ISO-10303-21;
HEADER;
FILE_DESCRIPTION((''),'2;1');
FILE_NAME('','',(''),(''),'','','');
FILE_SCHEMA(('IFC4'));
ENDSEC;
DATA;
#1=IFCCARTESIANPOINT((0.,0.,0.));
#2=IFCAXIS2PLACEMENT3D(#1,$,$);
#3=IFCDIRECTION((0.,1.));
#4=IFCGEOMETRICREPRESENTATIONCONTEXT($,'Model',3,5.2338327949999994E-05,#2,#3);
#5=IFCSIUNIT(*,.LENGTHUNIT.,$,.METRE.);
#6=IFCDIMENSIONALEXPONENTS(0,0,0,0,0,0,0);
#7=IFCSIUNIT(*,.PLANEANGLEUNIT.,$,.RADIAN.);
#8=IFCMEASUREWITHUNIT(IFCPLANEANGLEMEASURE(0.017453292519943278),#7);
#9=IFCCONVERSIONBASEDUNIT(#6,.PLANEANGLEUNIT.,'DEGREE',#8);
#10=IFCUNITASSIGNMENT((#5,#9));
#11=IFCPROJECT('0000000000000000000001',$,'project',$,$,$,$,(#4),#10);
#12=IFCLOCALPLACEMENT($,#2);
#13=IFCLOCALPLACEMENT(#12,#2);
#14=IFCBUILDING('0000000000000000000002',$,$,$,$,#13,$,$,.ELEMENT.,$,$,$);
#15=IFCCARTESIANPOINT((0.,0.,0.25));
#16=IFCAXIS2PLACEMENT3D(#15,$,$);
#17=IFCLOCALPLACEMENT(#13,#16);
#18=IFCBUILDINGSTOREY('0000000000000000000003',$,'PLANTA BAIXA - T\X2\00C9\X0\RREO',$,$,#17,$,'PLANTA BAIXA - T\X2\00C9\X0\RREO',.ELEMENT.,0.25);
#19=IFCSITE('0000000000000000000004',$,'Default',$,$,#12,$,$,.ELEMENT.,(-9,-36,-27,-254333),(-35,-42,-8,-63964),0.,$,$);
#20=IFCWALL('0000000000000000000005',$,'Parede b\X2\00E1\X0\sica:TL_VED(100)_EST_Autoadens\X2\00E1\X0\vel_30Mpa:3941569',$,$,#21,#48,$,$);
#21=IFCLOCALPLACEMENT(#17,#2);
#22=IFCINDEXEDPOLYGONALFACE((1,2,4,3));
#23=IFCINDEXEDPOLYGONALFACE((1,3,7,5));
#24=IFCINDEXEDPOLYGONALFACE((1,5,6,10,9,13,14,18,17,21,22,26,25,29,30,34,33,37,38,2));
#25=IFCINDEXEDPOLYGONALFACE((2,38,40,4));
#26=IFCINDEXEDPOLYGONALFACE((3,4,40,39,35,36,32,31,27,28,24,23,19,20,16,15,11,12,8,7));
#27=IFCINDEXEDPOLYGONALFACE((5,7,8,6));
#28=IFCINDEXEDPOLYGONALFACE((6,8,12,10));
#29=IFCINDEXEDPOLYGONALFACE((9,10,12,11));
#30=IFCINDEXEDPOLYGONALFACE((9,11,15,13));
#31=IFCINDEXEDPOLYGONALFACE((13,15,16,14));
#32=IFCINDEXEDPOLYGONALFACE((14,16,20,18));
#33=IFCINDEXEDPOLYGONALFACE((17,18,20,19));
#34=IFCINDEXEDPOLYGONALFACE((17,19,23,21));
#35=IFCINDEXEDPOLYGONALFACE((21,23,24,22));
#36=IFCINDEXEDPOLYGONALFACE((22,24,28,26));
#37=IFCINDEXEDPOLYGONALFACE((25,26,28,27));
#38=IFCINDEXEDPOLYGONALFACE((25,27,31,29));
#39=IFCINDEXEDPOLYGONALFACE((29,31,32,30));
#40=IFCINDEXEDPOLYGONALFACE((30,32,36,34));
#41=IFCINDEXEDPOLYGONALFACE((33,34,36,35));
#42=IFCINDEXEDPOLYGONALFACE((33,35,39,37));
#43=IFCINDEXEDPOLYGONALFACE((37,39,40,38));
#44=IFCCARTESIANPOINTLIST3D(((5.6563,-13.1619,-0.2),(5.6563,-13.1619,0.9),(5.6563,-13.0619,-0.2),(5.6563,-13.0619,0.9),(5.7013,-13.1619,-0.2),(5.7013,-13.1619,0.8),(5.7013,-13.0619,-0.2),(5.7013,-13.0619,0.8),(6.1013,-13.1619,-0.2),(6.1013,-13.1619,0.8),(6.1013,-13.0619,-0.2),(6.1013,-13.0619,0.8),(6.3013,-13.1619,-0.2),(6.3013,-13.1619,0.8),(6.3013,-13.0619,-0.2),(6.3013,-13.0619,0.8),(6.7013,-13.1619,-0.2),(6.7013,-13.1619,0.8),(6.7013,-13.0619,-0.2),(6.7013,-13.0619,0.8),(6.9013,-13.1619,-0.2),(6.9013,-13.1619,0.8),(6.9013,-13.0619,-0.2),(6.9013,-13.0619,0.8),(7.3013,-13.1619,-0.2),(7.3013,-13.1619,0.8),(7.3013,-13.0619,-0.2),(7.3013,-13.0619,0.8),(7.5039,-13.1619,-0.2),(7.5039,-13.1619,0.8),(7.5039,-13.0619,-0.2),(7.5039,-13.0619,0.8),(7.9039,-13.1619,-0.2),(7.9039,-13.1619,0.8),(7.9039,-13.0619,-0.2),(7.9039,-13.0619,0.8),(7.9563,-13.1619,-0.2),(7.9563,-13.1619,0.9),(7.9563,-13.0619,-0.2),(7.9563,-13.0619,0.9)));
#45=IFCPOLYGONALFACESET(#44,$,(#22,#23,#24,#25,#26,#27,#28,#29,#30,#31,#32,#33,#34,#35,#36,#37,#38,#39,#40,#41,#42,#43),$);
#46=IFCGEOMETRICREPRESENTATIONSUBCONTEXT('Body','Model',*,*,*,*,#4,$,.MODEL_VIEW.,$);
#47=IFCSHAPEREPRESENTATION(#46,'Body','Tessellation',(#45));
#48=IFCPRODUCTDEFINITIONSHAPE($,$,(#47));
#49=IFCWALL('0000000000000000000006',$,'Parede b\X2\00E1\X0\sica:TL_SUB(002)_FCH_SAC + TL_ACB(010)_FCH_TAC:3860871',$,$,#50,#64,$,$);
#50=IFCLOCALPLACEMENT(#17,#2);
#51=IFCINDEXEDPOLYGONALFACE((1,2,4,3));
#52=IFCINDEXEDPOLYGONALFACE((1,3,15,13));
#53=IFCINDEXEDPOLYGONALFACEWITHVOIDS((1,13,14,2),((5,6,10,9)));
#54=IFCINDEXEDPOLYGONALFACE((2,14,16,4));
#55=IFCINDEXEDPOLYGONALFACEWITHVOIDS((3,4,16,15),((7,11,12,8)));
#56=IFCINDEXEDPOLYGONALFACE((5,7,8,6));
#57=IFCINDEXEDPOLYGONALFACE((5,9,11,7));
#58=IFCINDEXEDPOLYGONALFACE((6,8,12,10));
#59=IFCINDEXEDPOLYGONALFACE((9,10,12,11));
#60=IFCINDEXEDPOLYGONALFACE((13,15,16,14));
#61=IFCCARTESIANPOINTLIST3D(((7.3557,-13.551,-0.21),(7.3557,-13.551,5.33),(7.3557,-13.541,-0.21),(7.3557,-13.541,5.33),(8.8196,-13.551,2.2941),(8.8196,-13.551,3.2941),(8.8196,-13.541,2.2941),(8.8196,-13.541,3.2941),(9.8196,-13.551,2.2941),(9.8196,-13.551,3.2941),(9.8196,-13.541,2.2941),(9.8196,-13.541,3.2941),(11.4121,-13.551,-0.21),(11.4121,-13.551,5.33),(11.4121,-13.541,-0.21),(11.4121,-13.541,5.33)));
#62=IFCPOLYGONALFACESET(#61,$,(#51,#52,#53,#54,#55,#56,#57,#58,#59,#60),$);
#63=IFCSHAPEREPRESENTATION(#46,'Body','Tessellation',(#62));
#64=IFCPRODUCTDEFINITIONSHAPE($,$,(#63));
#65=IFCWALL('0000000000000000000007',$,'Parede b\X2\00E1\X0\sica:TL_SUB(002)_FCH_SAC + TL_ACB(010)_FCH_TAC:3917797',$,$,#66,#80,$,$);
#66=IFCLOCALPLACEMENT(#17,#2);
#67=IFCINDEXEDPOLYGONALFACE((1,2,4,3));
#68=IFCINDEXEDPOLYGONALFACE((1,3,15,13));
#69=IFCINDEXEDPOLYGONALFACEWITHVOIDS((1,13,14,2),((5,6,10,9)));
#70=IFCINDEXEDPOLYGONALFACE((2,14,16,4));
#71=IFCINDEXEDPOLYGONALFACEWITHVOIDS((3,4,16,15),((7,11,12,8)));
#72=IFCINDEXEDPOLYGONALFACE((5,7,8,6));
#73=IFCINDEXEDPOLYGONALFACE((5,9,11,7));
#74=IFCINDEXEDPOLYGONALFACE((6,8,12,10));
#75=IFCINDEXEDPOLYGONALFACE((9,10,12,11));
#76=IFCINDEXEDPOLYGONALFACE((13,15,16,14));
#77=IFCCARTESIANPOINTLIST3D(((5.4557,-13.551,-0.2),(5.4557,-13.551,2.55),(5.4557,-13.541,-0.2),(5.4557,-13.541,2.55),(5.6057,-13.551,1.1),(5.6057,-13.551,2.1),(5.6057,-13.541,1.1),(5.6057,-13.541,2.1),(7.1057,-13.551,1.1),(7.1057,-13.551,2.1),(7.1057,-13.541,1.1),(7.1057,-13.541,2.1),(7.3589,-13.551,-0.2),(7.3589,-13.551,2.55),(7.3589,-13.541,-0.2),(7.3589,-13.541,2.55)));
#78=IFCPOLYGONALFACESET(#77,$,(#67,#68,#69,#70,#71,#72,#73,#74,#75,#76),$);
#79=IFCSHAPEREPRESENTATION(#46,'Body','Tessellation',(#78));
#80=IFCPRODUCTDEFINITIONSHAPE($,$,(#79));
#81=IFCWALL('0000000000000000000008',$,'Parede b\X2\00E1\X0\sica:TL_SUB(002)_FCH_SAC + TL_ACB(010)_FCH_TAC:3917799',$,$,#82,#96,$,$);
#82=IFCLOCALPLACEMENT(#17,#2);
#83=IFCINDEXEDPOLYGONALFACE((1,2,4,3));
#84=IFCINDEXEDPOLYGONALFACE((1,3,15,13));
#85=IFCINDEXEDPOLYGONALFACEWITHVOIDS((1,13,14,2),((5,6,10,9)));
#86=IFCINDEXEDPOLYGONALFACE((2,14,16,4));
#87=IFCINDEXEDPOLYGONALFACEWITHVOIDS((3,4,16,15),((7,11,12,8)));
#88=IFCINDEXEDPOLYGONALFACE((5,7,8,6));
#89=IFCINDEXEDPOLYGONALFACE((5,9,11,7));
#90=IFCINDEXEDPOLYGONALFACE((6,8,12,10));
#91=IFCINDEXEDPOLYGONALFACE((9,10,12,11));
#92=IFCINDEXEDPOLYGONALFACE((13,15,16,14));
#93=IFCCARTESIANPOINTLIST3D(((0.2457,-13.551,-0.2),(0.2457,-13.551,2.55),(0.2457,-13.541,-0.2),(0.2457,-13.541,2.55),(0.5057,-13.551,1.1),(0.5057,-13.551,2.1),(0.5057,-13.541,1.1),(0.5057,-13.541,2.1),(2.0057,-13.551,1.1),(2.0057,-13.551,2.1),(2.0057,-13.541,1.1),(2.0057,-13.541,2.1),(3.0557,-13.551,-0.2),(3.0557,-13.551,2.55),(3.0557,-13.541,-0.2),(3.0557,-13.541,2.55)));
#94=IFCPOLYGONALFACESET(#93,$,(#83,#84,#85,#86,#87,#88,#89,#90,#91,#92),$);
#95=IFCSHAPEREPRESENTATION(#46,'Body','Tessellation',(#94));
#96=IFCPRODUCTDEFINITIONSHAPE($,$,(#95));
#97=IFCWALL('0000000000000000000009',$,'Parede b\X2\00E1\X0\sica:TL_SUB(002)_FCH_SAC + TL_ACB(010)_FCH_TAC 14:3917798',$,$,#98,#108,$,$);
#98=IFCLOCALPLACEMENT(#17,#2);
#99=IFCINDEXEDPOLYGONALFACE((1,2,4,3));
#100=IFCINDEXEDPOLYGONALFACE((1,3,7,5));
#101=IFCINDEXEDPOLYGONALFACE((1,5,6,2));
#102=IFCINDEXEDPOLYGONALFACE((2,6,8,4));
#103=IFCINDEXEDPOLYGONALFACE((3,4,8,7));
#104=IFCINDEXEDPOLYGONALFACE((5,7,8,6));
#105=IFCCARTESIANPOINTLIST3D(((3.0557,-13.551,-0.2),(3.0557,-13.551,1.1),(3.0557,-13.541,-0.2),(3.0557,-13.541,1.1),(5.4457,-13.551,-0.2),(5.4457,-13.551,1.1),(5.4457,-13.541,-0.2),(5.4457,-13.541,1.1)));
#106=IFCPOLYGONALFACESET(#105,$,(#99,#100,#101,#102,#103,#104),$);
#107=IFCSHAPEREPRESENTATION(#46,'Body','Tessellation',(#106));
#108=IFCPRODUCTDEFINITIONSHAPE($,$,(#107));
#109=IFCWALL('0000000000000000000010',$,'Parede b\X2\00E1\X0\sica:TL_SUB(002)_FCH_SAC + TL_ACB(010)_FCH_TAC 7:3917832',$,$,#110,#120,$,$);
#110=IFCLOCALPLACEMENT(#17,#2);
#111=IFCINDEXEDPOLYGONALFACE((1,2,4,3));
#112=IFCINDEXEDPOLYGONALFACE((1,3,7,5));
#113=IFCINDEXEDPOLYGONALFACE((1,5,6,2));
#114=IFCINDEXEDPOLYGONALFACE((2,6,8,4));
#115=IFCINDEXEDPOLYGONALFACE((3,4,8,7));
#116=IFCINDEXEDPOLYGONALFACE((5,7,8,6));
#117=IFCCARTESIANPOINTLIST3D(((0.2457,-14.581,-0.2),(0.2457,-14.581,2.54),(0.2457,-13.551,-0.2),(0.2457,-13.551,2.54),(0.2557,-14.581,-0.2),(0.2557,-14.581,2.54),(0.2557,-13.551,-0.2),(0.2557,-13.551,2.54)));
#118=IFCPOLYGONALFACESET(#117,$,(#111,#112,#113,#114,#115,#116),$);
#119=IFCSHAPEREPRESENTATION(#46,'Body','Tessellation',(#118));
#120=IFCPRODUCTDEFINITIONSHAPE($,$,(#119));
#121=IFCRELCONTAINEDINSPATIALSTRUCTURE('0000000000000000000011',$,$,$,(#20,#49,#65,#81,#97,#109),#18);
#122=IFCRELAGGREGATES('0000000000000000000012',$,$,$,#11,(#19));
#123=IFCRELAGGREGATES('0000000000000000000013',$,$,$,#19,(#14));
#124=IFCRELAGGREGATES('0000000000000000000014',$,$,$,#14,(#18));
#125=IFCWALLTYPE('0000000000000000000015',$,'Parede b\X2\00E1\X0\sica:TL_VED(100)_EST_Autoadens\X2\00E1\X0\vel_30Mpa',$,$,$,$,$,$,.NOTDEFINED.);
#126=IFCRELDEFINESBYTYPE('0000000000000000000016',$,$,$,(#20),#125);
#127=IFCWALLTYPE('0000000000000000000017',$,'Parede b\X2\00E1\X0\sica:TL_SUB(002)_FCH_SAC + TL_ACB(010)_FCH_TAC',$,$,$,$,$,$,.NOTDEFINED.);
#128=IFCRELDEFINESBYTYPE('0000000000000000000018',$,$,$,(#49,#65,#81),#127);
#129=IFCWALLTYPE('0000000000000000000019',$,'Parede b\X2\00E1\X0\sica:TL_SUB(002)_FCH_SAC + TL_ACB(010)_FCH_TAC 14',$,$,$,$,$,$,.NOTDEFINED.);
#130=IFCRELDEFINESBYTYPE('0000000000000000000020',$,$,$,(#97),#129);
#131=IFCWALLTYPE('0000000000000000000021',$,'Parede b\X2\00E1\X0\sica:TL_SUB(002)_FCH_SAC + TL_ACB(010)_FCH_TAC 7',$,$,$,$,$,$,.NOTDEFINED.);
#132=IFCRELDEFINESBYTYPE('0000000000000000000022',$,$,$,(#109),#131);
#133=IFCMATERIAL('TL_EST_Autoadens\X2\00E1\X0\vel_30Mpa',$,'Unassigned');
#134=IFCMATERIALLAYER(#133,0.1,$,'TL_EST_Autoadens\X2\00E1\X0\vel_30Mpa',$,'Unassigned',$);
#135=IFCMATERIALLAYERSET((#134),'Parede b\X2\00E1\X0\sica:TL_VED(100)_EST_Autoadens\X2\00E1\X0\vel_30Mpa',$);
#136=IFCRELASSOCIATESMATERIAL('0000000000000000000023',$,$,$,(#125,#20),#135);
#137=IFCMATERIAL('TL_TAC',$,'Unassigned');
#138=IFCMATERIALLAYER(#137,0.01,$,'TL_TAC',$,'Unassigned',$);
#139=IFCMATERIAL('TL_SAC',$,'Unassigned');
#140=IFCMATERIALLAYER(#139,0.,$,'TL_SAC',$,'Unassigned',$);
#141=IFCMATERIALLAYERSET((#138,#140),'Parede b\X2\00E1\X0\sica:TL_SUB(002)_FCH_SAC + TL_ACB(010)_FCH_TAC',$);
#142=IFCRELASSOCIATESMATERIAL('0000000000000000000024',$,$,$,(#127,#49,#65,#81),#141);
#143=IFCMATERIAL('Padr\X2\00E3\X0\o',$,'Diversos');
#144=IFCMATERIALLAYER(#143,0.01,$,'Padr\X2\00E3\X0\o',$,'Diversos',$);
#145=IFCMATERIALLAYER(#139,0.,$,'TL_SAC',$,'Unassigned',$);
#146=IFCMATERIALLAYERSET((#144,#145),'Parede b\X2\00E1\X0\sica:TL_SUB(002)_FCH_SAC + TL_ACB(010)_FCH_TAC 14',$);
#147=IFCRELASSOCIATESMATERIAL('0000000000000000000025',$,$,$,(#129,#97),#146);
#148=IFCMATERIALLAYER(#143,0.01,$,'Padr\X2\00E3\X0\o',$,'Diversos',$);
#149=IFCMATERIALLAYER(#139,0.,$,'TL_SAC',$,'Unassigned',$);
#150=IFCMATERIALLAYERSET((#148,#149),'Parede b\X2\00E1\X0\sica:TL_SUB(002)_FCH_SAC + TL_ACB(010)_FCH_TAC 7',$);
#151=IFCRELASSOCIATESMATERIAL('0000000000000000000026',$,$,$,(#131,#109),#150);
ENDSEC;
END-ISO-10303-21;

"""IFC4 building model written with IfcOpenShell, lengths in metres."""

from ifc_helpers import new_model, entity, si_unit, converted_unit, direction, frame, frame_2d, origin, place, context, subcontext, project, spatial, polyline, rectangle, extrude, clip, bounded_halfspace, material, layer, layer_set, layer_usage, type_object, element, save


model = new_model("IFC4")

# Units and contexts
model_context = context("Model", 3, precision=5.2338327949999994e-05, world=origin(), true_north=direction((0.0, 1.0)))
body_context = subcontext(model_context, "Body", "Model", "MODEL_VIEW")
ifc_project = project(units=[si_unit("LENGTHUNIT", "METRE"), converted_unit("PLANEANGLEUNIT", "DEGREE", entity("IfcPlaneAngleMeasure", 0.017453292519943278), si_unit("PLANEANGLEUNIT", "RADIAN"), dimensions=[0, 0, 0, 0, 0, 0, 0])], contexts=[model_context])

# Site, building, storey
site_placement = place(None, frame((0.0, 0.0, 0.0)))
site = spatial("IfcSite", under=ifc_project, at=site_placement, Name="Default", CompositionType="ELEMENT", RefLatitude=(-9, -36, -27, -254333), RefLongitude=(-35, -42, -8, -63964), RefElevation=0.0)
building_placement = place(site_placement, origin())
building = spatial("IfcBuilding", under=site, at=building_placement, CompositionType="ELEMENT")
storey_placement = place(building_placement, frame((0.0, 0.0, 0.25)))
storey = spatial("IfcBuildingStorey", under=building, at=storey_placement, Name="PLANTA BAIXA - TÉRREO", LongName="PLANTA BAIXA - TÉRREO", CompositionType="ELEMENT", Elevation=0.25)

# Shared definitions
ifc_material_1 = material(Name="TL_EST_Autoadensável_30Mpa", Category="Unassigned")
ifc_layer_1 = layer(ifc_material_1, 0.1, Name="TL_EST_Autoadensável_30Mpa", Category="Unassigned")
ifc_layer_set_1 = layer_set([ifc_layer_1], Name="Parede básica:TL_VED(100)_EST_Autoadensável_30Mpa")
wall_type_1 = type_object("IfcWallType", Name="Parede básica:TL_VED(100)_EST_Autoadensável_30Mpa", PredefinedType="NOTDEFINED", material=ifc_layer_set_1)

# Wall, openings
ifc_layer_usage_1 = layer_usage(ifc_layer_set_1, "AXIS2", "NEGATIVE", 0.05)
wall_1_placement = place(storey_placement, frame((5.6563, -13.1119, -0.2)))
wall_1 = element("IfcWall", 1, at=wall_1_placement, inside=storey, type_object=wall_type_1, material=ifc_layer_usage_1, Name="Parede básica:TL_VED(100)_EST_Autoadensável_30Mpa:3941569", context=body_context, shape_type="Clipping", body=[
    clip(extrude(rectangle(XDim=2.3, YDim=0.1, at=frame_2d((1.15, 0.0), x_axis=(-1.0, 0.0))), origin(), (0.0, 0.0, 1.0), 1.1), bounded_halfspace(frame((0.0, -0.05, 1.1), z_axis=(0.0, 0.0, -1.0), x_axis=(0.0, -1.0, 0.0)), True, frame((0.0, -0.05, 1.1)), polyline([(0.0, 0.0), (0.5, 0.0), (0.6, 0.0), (1.1, 0.0), (1.2, 0.0), (1.7027, 0.0), (1.8027, 0.0), (2.3, 0.0), (2.3, 0.05), (2.3, 0.1), (0.0, 0.1), (0.0, 0.0)]))),
])
opening_1_placement = place(wall_1_placement, frame((-5.6563, 13.1119, 0.0)))
element("IfcOpeningElement", 2, at=opening_1_placement, cuts=wall_1, PredefinedType="OPENING", context=body_context, shape_type="SweptSolid", body=[
    extrude(rectangle(XDim=1.0, YDim=0.4, at=frame_2d((0.0, 0.0), x_axis=(0.0, 1.0))), frame((7.7039, -13.8965, 0.5), z_axis=(0.0, 1.0, 0.0), x_axis=(1.0, 0.0, 0.0)), (0.0, 0.0, 1.0), 1.542),
])
opening_2_placement = place(wall_1_placement, frame((-5.6563, 13.1119, 0.0)))
element("IfcOpeningElement", 3, at=opening_2_placement, cuts=wall_1, PredefinedType="OPENING", context=body_context, shape_type="SweptSolid", body=[
    extrude(rectangle(XDim=1.0, YDim=0.4, at=frame_2d((0.0, 0.0), x_axis=(0.0, 1.0))), frame((7.1013, -13.8965, 0.5), z_axis=(0.0, 1.0, 0.0), x_axis=(1.0, 0.0, 0.0)), (0.0, 0.0, 1.0), 1.542),
])
opening_3_placement = place(wall_1_placement, frame((-5.6563, 13.1119, 0.0)))
element("IfcOpeningElement", 4, at=opening_3_placement, cuts=wall_1, PredefinedType="OPENING", context=body_context, shape_type="SweptSolid", body=[
    extrude(rectangle(XDim=1.0, YDim=0.4, at=frame_2d((0.0, 0.0), x_axis=(0.0, 1.0))), frame((6.5013, -13.8965, 0.5), z_axis=(0.0, 1.0, 0.0), x_axis=(1.0, 0.0, 0.0)), (0.0, 0.0, 1.0), 1.542),
])
opening_4_placement = place(wall_1_placement, frame((-5.6563, 13.1119, 0.0)))
element("IfcOpeningElement", 5, at=opening_4_placement, cuts=wall_1, PredefinedType="OPENING", context=body_context, shape_type="SweptSolid", body=[
    extrude(rectangle(XDim=1.0, YDim=0.4, at=frame_2d((0.0, 0.0), x_axis=(0.0, 1.0))), frame((5.9013, -13.8965, 0.5), z_axis=(0.0, 1.0, 0.0), x_axis=(1.0, 0.0, 0.0)), (0.0, 0.0, 1.0), 1.542),
])

# Walls, openings
ifc_material_2 = material(Name="TL_TAC", Category="Unassigned")
ifc_layer_2 = layer(ifc_material_2, 0.01, Name="TL_TAC", Category="Unassigned")
ifc_material_3 = material(Name="TL_SAC", Category="Unassigned")
ifc_layer_3 = layer(ifc_material_3, 0.0, Name="TL_SAC", Category="Unassigned")
ifc_layer_set_2 = layer_set([ifc_layer_2, ifc_layer_3], Name="Parede básica:TL_SUB(002)_FCH_SAC + TL_ACB(010)_FCH_TAC")
ifc_layer_usage_2 = layer_usage(ifc_layer_set_2, "AXIS2", "POSITIVE", -0.005)
wall_type_2 = type_object("IfcWallType", Name="Parede básica:TL_SUB(002)_FCH_SAC + TL_ACB(010)_FCH_TAC", PredefinedType="NOTDEFINED", material=ifc_layer_set_2)
wall_2_placement = place(storey_placement, frame((7.3557, -13.546, -0.21)))
wall_2 = element("IfcWall", 6, at=wall_2_placement, inside=storey, type_object=wall_type_2, material=ifc_layer_usage_2, Name="Parede básica:TL_SUB(002)_FCH_SAC + TL_ACB(010)_FCH_TAC:3860871", context=body_context, shape_type="SweptSolid", body=[
    extrude(rectangle(XDim=4.0564, YDim=0.01, at=frame_2d((2.0282, 0.0), x_axis=(-1.0, 0.0))), origin(), (0.0, 0.0, 1.0), 5.54),
])
opening_5_placement = place(wall_2_placement, frame((-7.3557, 13.546, 2.5041)))
element("IfcOpeningElement", 7, at=opening_5_placement, cuts=wall_2, PredefinedType="OPENING", context=body_context, shape_type="SweptSolid", body=[
    extrude(rectangle(XDim=1.0, YDim=1.0, at=frame_2d((0.0, 0.0), x_axis=(0.0, 1.0))), frame((9.3196, -15.1748, 0.5), z_axis=(0.0, 1.0, 0.0), x_axis=(1.0, 0.0, 0.0)), (0.0, 0.0, 1.0), 3.048),
])
ifc_layer_usage_3 = layer_usage(ifc_layer_set_2, "AXIS2", "NEGATIVE", 0.005)
wall_3_placement = place(storey_placement, frame((7.3589, -13.546, -0.2), z_axis=(0.0, 0.0, 1.0), x_axis=(-1.0, 0.0, 0.0)))
wall_3 = element("IfcWall", 8, at=wall_3_placement, inside=storey, type_object=wall_type_2, material=ifc_layer_usage_3, Name="Parede básica:TL_SUB(002)_FCH_SAC + TL_ACB(010)_FCH_TAC:3917797", context=body_context, shape_type="SweptSolid", body=[
    extrude(rectangle(XDim=1.9032, YDim=0.01, at=frame_2d((0.9516, 0.0), x_axis=(-1.0, 0.0))), origin(), (0.0, 0.0, 1.0), 2.75),
])
opening_6_placement = place(wall_3_placement, frame((7.3589, -13.546, 1.3)))
element("IfcOpeningElement", 9, at=opening_6_placement, cuts=wall_3, PredefinedType="OPENING", context=body_context, shape_type="SweptSolid", body=[
    extrude(rectangle(XDim=1.0, YDim=1.5, at=frame_2d((0.0, 0.0), x_axis=(0.0, 1.0))), frame((-6.3557, 12.127, 0.5), z_axis=(0.0, 1.0, 0.0), x_axis=(1.0, 0.0, 0.0)), (0.0, 0.0, 1.0), 3.048),
])
ifc_layer_usage_4 = layer_usage(ifc_layer_set_2, "AXIS2", "POSITIVE", -0.005)
wall_4_placement = place(storey_placement, frame((3.0557, -13.546, -0.2), z_axis=(0.0, 0.0, 1.0), x_axis=(-1.0, 0.0, 0.0)))
wall_4 = element("IfcWall", 10, at=wall_4_placement, inside=storey, type_object=wall_type_2, material=ifc_layer_usage_4, Name="Parede básica:TL_SUB(002)_FCH_SAC + TL_ACB(010)_FCH_TAC:3917799", context=body_context, shape_type="SweptSolid", body=[
    extrude(rectangle(XDim=2.81, YDim=0.01, at=frame_2d((1.405, 0.0), x_axis=(-1.0, 0.0))), origin(), (0.0, 0.0, 1.0), 2.75),
])
opening_7_placement = place(wall_4_placement, frame((3.0557, -13.546, 1.3)))
element("IfcOpeningElement", 11, at=opening_7_placement, cuts=wall_4, PredefinedType="OPENING", context=body_context, shape_type="SweptSolid", body=[
    extrude(rectangle(XDim=1.0, YDim=1.5, at=frame_2d((0.0, 0.0), x_axis=(0.0, 1.0))), frame((-1.2557, 12.127, 0.5), z_axis=(0.0, 1.0, 0.0), x_axis=(1.0, 0.0, 0.0)), (0.0, 0.0, 1.0), 3.048),
])

# Walls
ifc_material_4 = material(Name="Padrão", Category="Diversos")
ifc_layer_4 = layer(ifc_material_4, 0.01, Name="Padrão", Category="Diversos")
ifc_layer_5 = layer(ifc_material_3, 0.0, Name="TL_SAC", Category="Unassigned")
ifc_layer_set_3 = layer_set([ifc_layer_4, ifc_layer_5], Name="Parede básica:TL_SUB(002)_FCH_SAC + TL_ACB(010)_FCH_TAC 14")
ifc_layer_usage_5 = layer_usage(ifc_layer_set_3, "AXIS2", "NEGATIVE", 0.005)
wall_type_3 = type_object("IfcWallType", Name="Parede básica:TL_SUB(002)_FCH_SAC + TL_ACB(010)_FCH_TAC 14", PredefinedType="NOTDEFINED", material=ifc_layer_set_3)
wall_5_placement = place(storey_placement, frame((5.4457, -13.546, -0.2), z_axis=(0.0, 0.0, 1.0), x_axis=(-1.0, 0.0, 0.0)))
element("IfcWall", 12, at=wall_5_placement, inside=storey, type_object=wall_type_3, material=ifc_layer_usage_5, Name="Parede básica:TL_SUB(002)_FCH_SAC + TL_ACB(010)_FCH_TAC 14:3917798", context=body_context, shape_type="SweptSolid", body=[
    extrude(rectangle(XDim=2.39, YDim=0.01, at=frame_2d((1.195, 0.0), x_axis=(-1.0, 0.0))), origin(), (0.0, 0.0, 1.0), 1.3),
])
ifc_layer_6 = layer(ifc_material_4, 0.01, Name="Padrão", Category="Diversos")
ifc_layer_7 = layer(ifc_material_3, 0.0, Name="TL_SAC", Category="Unassigned")
ifc_layer_set_4 = layer_set([ifc_layer_6, ifc_layer_7], Name="Parede básica:TL_SUB(002)_FCH_SAC + TL_ACB(010)_FCH_TAC 7")
ifc_layer_usage_6 = layer_usage(ifc_layer_set_4, "AXIS2", "NEGATIVE", 0.005)
wall_type_4 = type_object("IfcWallType", Name="Parede básica:TL_SUB(002)_FCH_SAC + TL_ACB(010)_FCH_TAC 7", PredefinedType="NOTDEFINED", material=ifc_layer_set_4)
wall_6_placement = place(storey_placement, frame((0.2507, -13.551, -0.2), z_axis=(0.0, 0.0, 1.0), x_axis=(0.0, -1.0, 0.0)))
element("IfcWall", 13, at=wall_6_placement, inside=storey, type_object=wall_type_4, material=ifc_layer_usage_6, Name="Parede básica:TL_SUB(002)_FCH_SAC + TL_ACB(010)_FCH_TAC 7:3917832", context=body_context, shape_type="SweptSolid", body=[
    extrude(rectangle(XDim=1.03, YDim=0.01, at=frame_2d((0.515, 0.0), x_axis=(-1.0, 0.0))), origin(), (0.0, 0.0, 1.0), 2.74),
])

save(model, "model.ifc")
